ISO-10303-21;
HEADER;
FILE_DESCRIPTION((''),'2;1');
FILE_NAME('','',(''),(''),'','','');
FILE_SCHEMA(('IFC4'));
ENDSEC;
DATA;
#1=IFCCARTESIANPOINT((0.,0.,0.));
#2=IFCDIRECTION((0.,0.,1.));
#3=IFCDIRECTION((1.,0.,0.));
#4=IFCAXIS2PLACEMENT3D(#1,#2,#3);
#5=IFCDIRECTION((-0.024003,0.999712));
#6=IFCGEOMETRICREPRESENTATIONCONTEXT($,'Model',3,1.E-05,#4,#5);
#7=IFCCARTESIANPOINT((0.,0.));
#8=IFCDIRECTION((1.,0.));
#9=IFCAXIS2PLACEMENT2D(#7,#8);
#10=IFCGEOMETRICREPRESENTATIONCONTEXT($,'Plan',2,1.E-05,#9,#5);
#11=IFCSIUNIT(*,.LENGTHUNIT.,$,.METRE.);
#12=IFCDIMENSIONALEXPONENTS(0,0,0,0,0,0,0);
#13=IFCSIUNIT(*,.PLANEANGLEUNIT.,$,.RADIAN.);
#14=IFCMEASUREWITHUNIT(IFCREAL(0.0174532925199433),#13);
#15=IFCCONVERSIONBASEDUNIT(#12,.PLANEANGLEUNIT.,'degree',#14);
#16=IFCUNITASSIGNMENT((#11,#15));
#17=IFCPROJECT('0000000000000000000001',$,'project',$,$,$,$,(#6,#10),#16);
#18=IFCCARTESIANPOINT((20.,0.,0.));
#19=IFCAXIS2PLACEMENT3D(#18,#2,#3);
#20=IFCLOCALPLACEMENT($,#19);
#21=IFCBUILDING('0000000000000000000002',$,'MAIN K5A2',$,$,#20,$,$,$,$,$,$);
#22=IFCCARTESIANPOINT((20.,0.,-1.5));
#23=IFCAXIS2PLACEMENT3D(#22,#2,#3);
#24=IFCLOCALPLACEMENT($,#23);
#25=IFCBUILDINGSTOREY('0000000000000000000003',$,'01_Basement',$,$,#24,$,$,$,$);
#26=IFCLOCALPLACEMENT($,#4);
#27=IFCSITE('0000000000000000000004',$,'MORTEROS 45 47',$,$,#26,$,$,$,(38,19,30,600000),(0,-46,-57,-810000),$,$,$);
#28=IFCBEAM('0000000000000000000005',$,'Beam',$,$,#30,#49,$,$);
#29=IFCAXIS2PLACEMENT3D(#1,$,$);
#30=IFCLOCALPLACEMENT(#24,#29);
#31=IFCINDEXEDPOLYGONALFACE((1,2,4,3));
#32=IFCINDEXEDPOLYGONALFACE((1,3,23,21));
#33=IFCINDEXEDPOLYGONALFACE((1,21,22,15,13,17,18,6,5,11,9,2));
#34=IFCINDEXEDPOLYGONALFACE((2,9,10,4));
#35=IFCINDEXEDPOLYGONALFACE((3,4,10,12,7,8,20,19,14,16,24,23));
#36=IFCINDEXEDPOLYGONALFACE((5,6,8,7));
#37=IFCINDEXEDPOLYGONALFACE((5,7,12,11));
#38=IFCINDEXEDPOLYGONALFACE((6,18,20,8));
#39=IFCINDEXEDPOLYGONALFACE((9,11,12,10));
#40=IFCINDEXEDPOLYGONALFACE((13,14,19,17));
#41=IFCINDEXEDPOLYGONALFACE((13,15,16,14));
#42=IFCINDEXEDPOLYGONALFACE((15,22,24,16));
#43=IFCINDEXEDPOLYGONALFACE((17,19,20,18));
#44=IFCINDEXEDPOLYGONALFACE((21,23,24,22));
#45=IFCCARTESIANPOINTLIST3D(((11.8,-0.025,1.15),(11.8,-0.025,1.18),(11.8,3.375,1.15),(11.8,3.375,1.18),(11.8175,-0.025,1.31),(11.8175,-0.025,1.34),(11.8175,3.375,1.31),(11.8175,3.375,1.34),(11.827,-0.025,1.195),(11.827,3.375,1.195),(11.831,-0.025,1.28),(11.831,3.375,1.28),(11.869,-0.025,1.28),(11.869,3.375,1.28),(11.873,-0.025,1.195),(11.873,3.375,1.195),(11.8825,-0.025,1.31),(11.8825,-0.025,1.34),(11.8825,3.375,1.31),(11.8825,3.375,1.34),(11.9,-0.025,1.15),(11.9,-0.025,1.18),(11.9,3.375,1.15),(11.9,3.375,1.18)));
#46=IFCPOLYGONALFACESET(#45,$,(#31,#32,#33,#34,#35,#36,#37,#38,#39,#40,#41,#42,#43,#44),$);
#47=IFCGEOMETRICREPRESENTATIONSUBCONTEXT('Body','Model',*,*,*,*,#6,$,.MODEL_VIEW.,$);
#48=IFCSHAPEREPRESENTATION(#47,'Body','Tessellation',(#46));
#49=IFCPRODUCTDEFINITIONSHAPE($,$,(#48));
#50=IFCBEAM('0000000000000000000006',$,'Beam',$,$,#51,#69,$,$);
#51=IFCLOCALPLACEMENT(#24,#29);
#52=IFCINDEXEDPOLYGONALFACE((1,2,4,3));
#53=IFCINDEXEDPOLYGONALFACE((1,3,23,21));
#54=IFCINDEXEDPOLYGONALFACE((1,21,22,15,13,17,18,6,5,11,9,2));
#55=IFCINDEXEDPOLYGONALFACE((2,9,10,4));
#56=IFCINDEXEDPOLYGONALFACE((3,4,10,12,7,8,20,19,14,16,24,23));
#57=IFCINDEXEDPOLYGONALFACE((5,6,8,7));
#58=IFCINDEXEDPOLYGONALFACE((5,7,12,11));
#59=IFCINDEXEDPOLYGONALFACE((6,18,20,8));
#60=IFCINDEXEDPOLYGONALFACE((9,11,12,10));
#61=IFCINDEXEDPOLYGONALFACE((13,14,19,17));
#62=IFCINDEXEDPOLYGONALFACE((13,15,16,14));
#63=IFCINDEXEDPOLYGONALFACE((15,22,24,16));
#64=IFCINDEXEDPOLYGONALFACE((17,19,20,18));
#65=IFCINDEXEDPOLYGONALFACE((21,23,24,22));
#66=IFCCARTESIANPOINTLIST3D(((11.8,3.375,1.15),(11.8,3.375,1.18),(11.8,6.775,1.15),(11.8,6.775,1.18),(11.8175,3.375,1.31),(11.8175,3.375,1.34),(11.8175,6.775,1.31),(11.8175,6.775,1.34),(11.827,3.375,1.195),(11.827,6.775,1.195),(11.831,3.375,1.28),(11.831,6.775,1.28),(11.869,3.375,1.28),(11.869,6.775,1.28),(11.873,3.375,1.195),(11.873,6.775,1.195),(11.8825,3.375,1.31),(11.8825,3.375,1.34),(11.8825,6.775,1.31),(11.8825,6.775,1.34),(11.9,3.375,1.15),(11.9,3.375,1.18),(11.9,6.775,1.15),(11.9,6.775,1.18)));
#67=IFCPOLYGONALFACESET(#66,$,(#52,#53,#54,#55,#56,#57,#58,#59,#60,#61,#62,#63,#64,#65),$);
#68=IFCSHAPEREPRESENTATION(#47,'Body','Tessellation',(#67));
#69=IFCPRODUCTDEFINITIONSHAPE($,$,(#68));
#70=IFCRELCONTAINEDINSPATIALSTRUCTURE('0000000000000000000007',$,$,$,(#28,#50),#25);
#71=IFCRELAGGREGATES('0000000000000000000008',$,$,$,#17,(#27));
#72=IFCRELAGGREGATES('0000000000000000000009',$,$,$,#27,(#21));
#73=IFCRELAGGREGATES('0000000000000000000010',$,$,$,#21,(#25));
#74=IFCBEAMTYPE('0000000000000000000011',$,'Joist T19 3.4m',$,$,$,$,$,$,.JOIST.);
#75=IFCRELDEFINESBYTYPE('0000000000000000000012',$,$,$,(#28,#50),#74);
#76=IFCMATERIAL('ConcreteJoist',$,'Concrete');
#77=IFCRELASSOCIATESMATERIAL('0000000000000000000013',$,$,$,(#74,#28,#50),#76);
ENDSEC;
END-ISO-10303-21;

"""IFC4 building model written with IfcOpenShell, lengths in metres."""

from ifc_helpers import new_model, entity, si_unit, converted_unit, direction, frame, origin_with_axes, origin_2d_with_axis, place, context, subcontext, project, spatial, indexed_curve, outline, extrude, material, material_profile, profile_set, profile_usage, type_object, element, save


model = new_model("IFC4")

# Units and contexts
model_context = context("Model", 3, precision=1e-05, world=origin_with_axes(), true_north=direction((-0.024003, 0.999712)))
plan_context = context("Plan", 2, precision=1e-05, world=origin_2d_with_axis(), true_north=direction((-0.024003, 0.999712)))
body_context = subcontext(model_context, "Body", "Model", "MODEL_VIEW")
ifc_project = project(units=[si_unit("LENGTHUNIT", "METRE"), converted_unit("PLANEANGLEUNIT", "degree", entity("IfcReal", 0.0174532925199433), si_unit("PLANEANGLEUNIT", "RADIAN"), dimensions=[0, 0, 0, 0, 0, 0, 0])], contexts=[model_context, plan_context])

# Site, building, storey
site_placement = place(None, origin_with_axes())
site = spatial("IfcSite", under=ifc_project, at=site_placement, Name="MORTEROS 45 47", RefLatitude=(38, 19, 30, 600000), RefLongitude=(0, -46, -57, -810000))
building_placement = place(None, frame((20.0, 0.0, 0.0), z_axis=(0.0, 0.0, 1.0), x_axis=(1.0, 0.0, 0.0)))
building = spatial("IfcBuilding", under=site, at=building_placement, Name="MAIN K5A2")
storey_placement = place(None, frame((20.0, 0.0, -1.5), z_axis=(0.0, 0.0, 1.0), x_axis=(1.0, 0.0, 0.0)))
storey = spatial("IfcBuildingStorey", under=building, at=storey_placement, Name="01_Basement")

# Beams
ifc_material = material(Name="ConcreteJoist", Category="Concrete")
ifc_material_profile = material_profile(ifc_material, outline(indexed_curve([(0.019, 0.13), (0.023, 0.045), (0.05, 0.03), (0.05, 0.0), (-0.05, 0.0), (-0.05, 0.03), (-0.023, 0.045), (-0.019, 0.13), (-0.0325, 0.16), (-0.0325, 0.19), (0.0325, 0.19), (0.0325, 0.16), (0.019, 0.13)])))
ifc_profile_set = profile_set([ifc_material_profile], Name="JoistMaterialProfileSet")
beam_type = type_object("IfcBeamType", Name="Joist T19 3.4m", PredefinedType="JOIST", material=ifc_profile_set)
ifc_profile_usage_1 = profile_usage(ifc_profile_set, cardinal=5)
beam_1_placement = place(None, frame((31.85, -0.025, -0.35), z_axis=(0.0, 1.0, 0.0), x_axis=(-1.0, 0.0, 0.0)))
element("IfcBeam", 1, at=beam_1_placement, inside=storey, type_object=beam_type, material=ifc_profile_usage_1, Name="Beam", context=body_context, shape_type="SweptSolid", body=[
    extrude(outline(indexed_curve([(0.019, 0.13), (0.023, 0.045), (0.05, 0.03), (0.05, 0.0), (-0.05, 0.0), (-0.05, 0.03), (-0.023, 0.045), (-0.019, 0.13), (-0.0325, 0.16), (-0.0325, 0.19), (0.0325, 0.19), (0.0325, 0.16), (0.019, 0.13)])), origin_with_axes(), (0.0, 0.0, 1.0), 3.4),
])
ifc_profile_usage_2 = profile_usage(ifc_profile_set, cardinal=5)
beam_2_placement = place(None, frame((31.85, 3.375, -0.35), z_axis=(0.0, 1.0, 0.0), x_axis=(-1.0, 0.0, 0.0)))
element("IfcBeam", 2, at=beam_2_placement, inside=storey, type_object=beam_type, material=ifc_profile_usage_2, Name="Beam", context=body_context, shape_type="SweptSolid", body=[
    extrude(outline(indexed_curve([(0.019, 0.13), (0.023, 0.045), (0.05, 0.03), (0.05, 0.0), (-0.05, 0.0), (-0.05, 0.03), (-0.023, 0.045), (-0.019, 0.13), (-0.0325, 0.16), (-0.0325, 0.19), (0.0325, 0.19), (0.0325, 0.16), (0.019, 0.13)])), origin_with_axes(), (0.0, 0.0, 1.0), 3.4),
])

save(model, "model.ifc")
